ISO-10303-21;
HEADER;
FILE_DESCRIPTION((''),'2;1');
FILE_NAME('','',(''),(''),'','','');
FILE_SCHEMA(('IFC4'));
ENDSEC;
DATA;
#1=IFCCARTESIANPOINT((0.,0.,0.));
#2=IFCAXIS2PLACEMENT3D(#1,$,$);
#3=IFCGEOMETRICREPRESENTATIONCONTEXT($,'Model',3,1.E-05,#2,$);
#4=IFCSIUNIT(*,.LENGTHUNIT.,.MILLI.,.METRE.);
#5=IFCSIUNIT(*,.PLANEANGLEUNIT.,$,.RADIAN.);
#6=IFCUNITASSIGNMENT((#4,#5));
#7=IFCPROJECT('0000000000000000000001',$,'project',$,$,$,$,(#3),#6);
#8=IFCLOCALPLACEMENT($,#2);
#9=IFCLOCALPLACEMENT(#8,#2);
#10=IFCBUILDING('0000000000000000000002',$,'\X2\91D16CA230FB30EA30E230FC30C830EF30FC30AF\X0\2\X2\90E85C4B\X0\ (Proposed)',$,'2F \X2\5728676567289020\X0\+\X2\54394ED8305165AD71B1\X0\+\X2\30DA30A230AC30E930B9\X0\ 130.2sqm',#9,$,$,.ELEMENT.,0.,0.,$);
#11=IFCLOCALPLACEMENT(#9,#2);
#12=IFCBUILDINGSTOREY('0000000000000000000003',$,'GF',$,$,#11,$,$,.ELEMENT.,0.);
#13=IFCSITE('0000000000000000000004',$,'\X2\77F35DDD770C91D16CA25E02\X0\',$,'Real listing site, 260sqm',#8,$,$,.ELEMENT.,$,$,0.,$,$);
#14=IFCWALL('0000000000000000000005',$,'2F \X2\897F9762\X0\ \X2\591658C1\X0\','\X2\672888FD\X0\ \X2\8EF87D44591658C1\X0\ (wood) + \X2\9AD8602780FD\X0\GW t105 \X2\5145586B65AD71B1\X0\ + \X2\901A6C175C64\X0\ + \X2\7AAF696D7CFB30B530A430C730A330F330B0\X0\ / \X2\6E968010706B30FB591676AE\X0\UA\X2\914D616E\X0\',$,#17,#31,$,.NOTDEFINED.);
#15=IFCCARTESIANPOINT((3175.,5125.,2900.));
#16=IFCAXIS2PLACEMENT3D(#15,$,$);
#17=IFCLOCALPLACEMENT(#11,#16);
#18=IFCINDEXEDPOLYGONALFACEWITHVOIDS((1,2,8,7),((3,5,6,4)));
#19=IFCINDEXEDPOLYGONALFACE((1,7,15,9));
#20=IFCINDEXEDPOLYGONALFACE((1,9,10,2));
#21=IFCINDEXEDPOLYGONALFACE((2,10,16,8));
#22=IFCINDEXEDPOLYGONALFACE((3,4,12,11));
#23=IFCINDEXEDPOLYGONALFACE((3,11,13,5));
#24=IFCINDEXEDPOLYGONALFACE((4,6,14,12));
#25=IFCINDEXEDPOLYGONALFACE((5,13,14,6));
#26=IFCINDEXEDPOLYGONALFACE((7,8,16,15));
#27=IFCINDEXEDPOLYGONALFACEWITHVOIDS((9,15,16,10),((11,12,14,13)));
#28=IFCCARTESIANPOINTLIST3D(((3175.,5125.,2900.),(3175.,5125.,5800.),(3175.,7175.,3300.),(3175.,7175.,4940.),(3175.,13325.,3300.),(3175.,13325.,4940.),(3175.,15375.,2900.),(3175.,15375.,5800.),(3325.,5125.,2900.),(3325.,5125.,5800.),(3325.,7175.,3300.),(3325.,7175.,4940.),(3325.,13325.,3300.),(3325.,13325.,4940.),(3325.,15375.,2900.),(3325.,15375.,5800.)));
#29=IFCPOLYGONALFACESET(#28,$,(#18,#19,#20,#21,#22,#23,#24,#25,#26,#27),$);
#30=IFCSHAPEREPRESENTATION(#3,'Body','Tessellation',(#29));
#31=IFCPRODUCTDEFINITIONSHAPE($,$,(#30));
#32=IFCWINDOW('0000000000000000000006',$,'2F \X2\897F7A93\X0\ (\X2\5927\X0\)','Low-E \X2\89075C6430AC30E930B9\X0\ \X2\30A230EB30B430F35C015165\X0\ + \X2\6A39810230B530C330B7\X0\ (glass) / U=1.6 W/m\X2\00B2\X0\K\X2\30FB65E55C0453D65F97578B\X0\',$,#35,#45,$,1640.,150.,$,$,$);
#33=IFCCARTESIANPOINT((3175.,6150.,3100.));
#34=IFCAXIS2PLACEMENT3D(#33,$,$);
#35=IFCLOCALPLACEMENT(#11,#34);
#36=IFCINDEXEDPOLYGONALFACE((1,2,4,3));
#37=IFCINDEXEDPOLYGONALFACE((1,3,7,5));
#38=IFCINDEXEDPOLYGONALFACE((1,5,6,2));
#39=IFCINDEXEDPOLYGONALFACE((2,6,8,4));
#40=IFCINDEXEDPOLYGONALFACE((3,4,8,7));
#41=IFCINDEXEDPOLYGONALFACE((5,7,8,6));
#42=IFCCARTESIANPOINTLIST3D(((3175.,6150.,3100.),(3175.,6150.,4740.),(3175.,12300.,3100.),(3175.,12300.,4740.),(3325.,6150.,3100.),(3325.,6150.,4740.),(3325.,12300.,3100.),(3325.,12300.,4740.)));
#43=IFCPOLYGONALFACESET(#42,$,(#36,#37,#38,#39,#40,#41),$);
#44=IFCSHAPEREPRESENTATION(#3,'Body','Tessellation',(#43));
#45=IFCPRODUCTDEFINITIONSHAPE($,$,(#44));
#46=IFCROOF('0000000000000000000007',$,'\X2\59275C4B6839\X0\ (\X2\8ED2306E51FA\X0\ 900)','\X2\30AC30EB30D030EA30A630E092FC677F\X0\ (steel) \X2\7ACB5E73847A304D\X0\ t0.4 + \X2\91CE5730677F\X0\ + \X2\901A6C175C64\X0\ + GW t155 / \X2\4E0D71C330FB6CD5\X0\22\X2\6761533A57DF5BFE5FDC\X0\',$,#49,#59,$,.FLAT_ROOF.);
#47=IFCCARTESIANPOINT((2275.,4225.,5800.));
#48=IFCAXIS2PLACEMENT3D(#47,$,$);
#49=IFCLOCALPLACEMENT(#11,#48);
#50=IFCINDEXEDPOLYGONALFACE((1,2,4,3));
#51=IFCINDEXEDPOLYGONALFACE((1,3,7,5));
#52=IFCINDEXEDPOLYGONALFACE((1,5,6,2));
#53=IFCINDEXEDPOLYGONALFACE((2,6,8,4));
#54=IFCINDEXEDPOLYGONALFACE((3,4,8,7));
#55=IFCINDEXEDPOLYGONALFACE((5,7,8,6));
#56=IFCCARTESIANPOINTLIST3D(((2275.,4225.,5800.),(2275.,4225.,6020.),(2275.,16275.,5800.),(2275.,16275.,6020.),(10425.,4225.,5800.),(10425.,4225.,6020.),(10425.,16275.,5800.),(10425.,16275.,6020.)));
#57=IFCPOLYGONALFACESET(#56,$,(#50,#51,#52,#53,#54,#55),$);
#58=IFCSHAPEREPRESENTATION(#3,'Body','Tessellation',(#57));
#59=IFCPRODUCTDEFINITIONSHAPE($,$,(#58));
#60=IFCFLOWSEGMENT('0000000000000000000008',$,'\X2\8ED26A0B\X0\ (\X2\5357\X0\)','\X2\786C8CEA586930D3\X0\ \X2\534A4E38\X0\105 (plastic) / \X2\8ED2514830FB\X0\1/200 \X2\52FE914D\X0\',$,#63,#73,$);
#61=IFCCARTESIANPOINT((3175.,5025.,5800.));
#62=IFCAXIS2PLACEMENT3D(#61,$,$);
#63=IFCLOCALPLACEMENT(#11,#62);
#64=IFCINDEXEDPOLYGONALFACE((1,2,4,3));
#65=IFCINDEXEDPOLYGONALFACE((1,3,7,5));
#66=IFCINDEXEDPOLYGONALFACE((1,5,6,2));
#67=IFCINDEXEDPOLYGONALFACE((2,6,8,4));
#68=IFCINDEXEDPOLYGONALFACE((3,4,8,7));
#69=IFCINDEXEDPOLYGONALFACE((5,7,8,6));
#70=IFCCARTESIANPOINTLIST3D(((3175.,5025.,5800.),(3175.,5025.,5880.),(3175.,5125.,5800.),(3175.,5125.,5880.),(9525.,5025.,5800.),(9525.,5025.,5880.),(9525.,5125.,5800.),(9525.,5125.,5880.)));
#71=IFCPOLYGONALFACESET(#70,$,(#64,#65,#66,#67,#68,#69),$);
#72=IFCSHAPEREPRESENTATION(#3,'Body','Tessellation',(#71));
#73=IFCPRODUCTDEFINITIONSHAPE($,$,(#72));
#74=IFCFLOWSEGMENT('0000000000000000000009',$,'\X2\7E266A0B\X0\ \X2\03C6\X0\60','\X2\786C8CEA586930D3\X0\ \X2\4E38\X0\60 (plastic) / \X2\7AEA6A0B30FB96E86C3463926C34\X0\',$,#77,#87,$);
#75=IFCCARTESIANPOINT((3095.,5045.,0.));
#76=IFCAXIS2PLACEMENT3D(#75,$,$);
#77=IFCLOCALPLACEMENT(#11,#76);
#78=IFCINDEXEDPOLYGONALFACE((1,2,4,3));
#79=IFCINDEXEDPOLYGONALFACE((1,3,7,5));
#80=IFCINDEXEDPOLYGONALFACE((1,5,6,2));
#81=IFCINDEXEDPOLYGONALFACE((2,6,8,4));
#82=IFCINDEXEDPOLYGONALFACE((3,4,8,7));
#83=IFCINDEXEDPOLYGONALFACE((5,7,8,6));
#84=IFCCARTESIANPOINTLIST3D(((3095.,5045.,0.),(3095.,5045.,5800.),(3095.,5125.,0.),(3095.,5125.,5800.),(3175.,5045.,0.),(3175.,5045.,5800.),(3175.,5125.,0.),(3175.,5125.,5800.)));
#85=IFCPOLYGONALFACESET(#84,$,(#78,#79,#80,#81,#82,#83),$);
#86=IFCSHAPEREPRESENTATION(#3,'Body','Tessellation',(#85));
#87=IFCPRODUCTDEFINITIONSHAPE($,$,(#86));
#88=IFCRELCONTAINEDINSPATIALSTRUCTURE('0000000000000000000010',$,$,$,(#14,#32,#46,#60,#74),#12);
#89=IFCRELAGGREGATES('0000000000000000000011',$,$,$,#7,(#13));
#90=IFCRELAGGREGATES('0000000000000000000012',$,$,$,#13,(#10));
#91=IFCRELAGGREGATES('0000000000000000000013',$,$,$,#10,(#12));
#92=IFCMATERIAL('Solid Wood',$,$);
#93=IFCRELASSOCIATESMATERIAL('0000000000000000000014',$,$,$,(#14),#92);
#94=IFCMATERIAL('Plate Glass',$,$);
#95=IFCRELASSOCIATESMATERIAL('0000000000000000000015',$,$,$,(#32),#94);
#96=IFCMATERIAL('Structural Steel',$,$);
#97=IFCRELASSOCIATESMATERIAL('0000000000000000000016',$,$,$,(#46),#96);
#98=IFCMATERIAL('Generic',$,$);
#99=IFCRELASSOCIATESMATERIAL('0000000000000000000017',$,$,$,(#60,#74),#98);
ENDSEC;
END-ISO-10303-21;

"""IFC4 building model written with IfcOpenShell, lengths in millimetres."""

from ifc_helpers import new_model, si_unit, frame, frame_2d, origin, place, context, project, spatial, rectangle, extrude, material, element, fill, save


model = new_model("IFC4")

# Units and contexts
model_context = context("Model", 3, precision=1e-05, world=origin())
ifc_project = project(units=[si_unit("LENGTHUNIT", "METRE", prefix="MILLI"), si_unit("PLANEANGLEUNIT", "RADIAN")], contexts=[model_context])

# Site, building, storey
site_placement = place(None, origin())
site = spatial("IfcSite", under=ifc_project, at=site_placement, Name="石川県金沢市", ObjectType="Real listing site, 260sqm", CompositionType="ELEMENT", RefElevation=0.0)
building_placement = place(site_placement, origin())
building = spatial("IfcBuilding", under=site, at=building_placement, Name="金沢・リモートワーク2部屋 (Proposed)", ObjectType="2F 在来木造+吹付け断熱+ペアガラス 130.2sqm", CompositionType="ELEMENT", ElevationOfRefHeight=0.0, ElevationOfTerrain=0.0)
storey_placement = place(building_placement, origin())
storey = spatial("IfcBuildingStorey", under=building, at=storey_placement, Name="GF", CompositionType="ELEMENT", Elevation=0.0)

# Shared definitions
ifc_material_1 = material(Name="Solid Wood")

# Shared definitions
ifc_material_2 = material(Name="Plate Glass")

# Wall, opening, window
wall_1_placement = place(storey_placement, frame((3175.0, 5125.0, 2900.0)))
wall_1 = element("IfcWall", 1, at=wall_1_placement, inside=storey, material=ifc_material_1, Name="2F 西面 外壁", Description="木製 軸組外壁 (wood) + 高性能GW t105 充填断熱 + 通気層 + 窯業系サイディング / 準耐火・外皮UA配慮", PredefinedType="NOTDEFINED", context=model_context, shape_type="SweptSolid", body=[
    extrude(rectangle(XDim=150.0, YDim=10250.0, at=frame_2d((75.0, 5125.0))), frame((3175.0, 5125.0, 2900.0)), (0.0, 0.0, 1.0), 2900.0),
])
opening_1_placement = place(storey_placement, frame((3175.0, 6150.0, 3100.0)))
opening_1 = element("IfcOpeningElement", 2, at=opening_1_placement, cuts=wall_1, PredefinedType="NOTDEFINED", context=model_context, shape_type="SweptSolid", body=[
    extrude(rectangle(XDim=150.0, YDim=6150.0, at=frame_2d((75.0, 3075.0))), frame((3175.0, 6150.0, 3100.0)), (0.0, 0.0, 1.0), 1640.0),
])
window_1_placement = place(storey_placement, frame((3175.0, 6150.0, 3100.0)))
window_1 = element("IfcWindow", 3, at=window_1_placement, inside=storey, material=ifc_material_2, Name="2F 西窓 (大)", Description="Low-E 複層ガラス アルゴン封入 + 樹脂サッシ (glass) / U=1.6 W/m²K・日射取得型", OverallHeight=1640.0, OverallWidth=150.0, context=model_context, shape_type="SweptSolid", body=[
    extrude(rectangle(XDim=150.0, YDim=6150.0, at=frame_2d((75.0, 3075.0))), frame((3175.0, 6150.0, 3100.0)), (0.0, 0.0, 1.0), 1640.0),
])
fill(opening_1, window_1)

# Roof
ifc_material_3 = material(Name="Structural Steel")
roof_placement = place(storey_placement, frame((2275.0, 4225.0, 5800.0)))
element("IfcRoof", 4, at=roof_placement, inside=storey, material=ifc_material_3, Name="大屋根 (軒の出 900)", Description="ガルバリウム鋼板 (steel) 立平葺き t0.4 + 野地板 + 通気層 + GW t155 / 不燃・法22条区域対応", PredefinedType="FLAT_ROOF", context=model_context, shape_type="SweptSolid", body=[
    extrude(rectangle(XDim=8150.0, YDim=12050.0, at=frame_2d((4075.0, 6025.0))), frame((2275.0, 4225.0, 5800.0)), (0.0, 0.0, 1.0), 220.0),
])

# Flow segments
ifc_material_4 = material(Name="Generic")
flow_segment_1_placement = place(storey_placement, frame((3175.0, 5025.0, 5800.0)))
element("IfcFlowSegment", 5, at=flow_segment_1_placement, inside=storey, material=ifc_material_4, Name="軒樋 (南)", Description="硬質塩ビ 半丸105 (plastic) / 軒先・1/200 勾配", context=model_context, shape_type="SweptSolid", body=[
    extrude(rectangle(XDim=6350.0, YDim=100.0, at=frame_2d((3175.0, 50.0))), frame((3175.0, 5025.0, 5800.0)), (0.0, 0.0, 1.0), 80.0),
])
flow_segment_2_placement = place(storey_placement, frame((3095.0, 5045.0, 0.0)))
element("IfcFlowSegment", 6, at=flow_segment_2_placement, inside=storey, material=ifc_material_4, Name="縦樋 φ60", Description="硬質塩ビ 丸60 (plastic) / 竪樋・雨水排水", context=model_context, shape_type="SweptSolid", body=[
    extrude(rectangle(XDim=80.0, YDim=80.0, at=frame_2d((40.0, 40.0))), frame((3095.0, 5045.0, 0.0)), (0.0, 0.0, 1.0), 5800.0),
])

save(model, "model.ifc")
